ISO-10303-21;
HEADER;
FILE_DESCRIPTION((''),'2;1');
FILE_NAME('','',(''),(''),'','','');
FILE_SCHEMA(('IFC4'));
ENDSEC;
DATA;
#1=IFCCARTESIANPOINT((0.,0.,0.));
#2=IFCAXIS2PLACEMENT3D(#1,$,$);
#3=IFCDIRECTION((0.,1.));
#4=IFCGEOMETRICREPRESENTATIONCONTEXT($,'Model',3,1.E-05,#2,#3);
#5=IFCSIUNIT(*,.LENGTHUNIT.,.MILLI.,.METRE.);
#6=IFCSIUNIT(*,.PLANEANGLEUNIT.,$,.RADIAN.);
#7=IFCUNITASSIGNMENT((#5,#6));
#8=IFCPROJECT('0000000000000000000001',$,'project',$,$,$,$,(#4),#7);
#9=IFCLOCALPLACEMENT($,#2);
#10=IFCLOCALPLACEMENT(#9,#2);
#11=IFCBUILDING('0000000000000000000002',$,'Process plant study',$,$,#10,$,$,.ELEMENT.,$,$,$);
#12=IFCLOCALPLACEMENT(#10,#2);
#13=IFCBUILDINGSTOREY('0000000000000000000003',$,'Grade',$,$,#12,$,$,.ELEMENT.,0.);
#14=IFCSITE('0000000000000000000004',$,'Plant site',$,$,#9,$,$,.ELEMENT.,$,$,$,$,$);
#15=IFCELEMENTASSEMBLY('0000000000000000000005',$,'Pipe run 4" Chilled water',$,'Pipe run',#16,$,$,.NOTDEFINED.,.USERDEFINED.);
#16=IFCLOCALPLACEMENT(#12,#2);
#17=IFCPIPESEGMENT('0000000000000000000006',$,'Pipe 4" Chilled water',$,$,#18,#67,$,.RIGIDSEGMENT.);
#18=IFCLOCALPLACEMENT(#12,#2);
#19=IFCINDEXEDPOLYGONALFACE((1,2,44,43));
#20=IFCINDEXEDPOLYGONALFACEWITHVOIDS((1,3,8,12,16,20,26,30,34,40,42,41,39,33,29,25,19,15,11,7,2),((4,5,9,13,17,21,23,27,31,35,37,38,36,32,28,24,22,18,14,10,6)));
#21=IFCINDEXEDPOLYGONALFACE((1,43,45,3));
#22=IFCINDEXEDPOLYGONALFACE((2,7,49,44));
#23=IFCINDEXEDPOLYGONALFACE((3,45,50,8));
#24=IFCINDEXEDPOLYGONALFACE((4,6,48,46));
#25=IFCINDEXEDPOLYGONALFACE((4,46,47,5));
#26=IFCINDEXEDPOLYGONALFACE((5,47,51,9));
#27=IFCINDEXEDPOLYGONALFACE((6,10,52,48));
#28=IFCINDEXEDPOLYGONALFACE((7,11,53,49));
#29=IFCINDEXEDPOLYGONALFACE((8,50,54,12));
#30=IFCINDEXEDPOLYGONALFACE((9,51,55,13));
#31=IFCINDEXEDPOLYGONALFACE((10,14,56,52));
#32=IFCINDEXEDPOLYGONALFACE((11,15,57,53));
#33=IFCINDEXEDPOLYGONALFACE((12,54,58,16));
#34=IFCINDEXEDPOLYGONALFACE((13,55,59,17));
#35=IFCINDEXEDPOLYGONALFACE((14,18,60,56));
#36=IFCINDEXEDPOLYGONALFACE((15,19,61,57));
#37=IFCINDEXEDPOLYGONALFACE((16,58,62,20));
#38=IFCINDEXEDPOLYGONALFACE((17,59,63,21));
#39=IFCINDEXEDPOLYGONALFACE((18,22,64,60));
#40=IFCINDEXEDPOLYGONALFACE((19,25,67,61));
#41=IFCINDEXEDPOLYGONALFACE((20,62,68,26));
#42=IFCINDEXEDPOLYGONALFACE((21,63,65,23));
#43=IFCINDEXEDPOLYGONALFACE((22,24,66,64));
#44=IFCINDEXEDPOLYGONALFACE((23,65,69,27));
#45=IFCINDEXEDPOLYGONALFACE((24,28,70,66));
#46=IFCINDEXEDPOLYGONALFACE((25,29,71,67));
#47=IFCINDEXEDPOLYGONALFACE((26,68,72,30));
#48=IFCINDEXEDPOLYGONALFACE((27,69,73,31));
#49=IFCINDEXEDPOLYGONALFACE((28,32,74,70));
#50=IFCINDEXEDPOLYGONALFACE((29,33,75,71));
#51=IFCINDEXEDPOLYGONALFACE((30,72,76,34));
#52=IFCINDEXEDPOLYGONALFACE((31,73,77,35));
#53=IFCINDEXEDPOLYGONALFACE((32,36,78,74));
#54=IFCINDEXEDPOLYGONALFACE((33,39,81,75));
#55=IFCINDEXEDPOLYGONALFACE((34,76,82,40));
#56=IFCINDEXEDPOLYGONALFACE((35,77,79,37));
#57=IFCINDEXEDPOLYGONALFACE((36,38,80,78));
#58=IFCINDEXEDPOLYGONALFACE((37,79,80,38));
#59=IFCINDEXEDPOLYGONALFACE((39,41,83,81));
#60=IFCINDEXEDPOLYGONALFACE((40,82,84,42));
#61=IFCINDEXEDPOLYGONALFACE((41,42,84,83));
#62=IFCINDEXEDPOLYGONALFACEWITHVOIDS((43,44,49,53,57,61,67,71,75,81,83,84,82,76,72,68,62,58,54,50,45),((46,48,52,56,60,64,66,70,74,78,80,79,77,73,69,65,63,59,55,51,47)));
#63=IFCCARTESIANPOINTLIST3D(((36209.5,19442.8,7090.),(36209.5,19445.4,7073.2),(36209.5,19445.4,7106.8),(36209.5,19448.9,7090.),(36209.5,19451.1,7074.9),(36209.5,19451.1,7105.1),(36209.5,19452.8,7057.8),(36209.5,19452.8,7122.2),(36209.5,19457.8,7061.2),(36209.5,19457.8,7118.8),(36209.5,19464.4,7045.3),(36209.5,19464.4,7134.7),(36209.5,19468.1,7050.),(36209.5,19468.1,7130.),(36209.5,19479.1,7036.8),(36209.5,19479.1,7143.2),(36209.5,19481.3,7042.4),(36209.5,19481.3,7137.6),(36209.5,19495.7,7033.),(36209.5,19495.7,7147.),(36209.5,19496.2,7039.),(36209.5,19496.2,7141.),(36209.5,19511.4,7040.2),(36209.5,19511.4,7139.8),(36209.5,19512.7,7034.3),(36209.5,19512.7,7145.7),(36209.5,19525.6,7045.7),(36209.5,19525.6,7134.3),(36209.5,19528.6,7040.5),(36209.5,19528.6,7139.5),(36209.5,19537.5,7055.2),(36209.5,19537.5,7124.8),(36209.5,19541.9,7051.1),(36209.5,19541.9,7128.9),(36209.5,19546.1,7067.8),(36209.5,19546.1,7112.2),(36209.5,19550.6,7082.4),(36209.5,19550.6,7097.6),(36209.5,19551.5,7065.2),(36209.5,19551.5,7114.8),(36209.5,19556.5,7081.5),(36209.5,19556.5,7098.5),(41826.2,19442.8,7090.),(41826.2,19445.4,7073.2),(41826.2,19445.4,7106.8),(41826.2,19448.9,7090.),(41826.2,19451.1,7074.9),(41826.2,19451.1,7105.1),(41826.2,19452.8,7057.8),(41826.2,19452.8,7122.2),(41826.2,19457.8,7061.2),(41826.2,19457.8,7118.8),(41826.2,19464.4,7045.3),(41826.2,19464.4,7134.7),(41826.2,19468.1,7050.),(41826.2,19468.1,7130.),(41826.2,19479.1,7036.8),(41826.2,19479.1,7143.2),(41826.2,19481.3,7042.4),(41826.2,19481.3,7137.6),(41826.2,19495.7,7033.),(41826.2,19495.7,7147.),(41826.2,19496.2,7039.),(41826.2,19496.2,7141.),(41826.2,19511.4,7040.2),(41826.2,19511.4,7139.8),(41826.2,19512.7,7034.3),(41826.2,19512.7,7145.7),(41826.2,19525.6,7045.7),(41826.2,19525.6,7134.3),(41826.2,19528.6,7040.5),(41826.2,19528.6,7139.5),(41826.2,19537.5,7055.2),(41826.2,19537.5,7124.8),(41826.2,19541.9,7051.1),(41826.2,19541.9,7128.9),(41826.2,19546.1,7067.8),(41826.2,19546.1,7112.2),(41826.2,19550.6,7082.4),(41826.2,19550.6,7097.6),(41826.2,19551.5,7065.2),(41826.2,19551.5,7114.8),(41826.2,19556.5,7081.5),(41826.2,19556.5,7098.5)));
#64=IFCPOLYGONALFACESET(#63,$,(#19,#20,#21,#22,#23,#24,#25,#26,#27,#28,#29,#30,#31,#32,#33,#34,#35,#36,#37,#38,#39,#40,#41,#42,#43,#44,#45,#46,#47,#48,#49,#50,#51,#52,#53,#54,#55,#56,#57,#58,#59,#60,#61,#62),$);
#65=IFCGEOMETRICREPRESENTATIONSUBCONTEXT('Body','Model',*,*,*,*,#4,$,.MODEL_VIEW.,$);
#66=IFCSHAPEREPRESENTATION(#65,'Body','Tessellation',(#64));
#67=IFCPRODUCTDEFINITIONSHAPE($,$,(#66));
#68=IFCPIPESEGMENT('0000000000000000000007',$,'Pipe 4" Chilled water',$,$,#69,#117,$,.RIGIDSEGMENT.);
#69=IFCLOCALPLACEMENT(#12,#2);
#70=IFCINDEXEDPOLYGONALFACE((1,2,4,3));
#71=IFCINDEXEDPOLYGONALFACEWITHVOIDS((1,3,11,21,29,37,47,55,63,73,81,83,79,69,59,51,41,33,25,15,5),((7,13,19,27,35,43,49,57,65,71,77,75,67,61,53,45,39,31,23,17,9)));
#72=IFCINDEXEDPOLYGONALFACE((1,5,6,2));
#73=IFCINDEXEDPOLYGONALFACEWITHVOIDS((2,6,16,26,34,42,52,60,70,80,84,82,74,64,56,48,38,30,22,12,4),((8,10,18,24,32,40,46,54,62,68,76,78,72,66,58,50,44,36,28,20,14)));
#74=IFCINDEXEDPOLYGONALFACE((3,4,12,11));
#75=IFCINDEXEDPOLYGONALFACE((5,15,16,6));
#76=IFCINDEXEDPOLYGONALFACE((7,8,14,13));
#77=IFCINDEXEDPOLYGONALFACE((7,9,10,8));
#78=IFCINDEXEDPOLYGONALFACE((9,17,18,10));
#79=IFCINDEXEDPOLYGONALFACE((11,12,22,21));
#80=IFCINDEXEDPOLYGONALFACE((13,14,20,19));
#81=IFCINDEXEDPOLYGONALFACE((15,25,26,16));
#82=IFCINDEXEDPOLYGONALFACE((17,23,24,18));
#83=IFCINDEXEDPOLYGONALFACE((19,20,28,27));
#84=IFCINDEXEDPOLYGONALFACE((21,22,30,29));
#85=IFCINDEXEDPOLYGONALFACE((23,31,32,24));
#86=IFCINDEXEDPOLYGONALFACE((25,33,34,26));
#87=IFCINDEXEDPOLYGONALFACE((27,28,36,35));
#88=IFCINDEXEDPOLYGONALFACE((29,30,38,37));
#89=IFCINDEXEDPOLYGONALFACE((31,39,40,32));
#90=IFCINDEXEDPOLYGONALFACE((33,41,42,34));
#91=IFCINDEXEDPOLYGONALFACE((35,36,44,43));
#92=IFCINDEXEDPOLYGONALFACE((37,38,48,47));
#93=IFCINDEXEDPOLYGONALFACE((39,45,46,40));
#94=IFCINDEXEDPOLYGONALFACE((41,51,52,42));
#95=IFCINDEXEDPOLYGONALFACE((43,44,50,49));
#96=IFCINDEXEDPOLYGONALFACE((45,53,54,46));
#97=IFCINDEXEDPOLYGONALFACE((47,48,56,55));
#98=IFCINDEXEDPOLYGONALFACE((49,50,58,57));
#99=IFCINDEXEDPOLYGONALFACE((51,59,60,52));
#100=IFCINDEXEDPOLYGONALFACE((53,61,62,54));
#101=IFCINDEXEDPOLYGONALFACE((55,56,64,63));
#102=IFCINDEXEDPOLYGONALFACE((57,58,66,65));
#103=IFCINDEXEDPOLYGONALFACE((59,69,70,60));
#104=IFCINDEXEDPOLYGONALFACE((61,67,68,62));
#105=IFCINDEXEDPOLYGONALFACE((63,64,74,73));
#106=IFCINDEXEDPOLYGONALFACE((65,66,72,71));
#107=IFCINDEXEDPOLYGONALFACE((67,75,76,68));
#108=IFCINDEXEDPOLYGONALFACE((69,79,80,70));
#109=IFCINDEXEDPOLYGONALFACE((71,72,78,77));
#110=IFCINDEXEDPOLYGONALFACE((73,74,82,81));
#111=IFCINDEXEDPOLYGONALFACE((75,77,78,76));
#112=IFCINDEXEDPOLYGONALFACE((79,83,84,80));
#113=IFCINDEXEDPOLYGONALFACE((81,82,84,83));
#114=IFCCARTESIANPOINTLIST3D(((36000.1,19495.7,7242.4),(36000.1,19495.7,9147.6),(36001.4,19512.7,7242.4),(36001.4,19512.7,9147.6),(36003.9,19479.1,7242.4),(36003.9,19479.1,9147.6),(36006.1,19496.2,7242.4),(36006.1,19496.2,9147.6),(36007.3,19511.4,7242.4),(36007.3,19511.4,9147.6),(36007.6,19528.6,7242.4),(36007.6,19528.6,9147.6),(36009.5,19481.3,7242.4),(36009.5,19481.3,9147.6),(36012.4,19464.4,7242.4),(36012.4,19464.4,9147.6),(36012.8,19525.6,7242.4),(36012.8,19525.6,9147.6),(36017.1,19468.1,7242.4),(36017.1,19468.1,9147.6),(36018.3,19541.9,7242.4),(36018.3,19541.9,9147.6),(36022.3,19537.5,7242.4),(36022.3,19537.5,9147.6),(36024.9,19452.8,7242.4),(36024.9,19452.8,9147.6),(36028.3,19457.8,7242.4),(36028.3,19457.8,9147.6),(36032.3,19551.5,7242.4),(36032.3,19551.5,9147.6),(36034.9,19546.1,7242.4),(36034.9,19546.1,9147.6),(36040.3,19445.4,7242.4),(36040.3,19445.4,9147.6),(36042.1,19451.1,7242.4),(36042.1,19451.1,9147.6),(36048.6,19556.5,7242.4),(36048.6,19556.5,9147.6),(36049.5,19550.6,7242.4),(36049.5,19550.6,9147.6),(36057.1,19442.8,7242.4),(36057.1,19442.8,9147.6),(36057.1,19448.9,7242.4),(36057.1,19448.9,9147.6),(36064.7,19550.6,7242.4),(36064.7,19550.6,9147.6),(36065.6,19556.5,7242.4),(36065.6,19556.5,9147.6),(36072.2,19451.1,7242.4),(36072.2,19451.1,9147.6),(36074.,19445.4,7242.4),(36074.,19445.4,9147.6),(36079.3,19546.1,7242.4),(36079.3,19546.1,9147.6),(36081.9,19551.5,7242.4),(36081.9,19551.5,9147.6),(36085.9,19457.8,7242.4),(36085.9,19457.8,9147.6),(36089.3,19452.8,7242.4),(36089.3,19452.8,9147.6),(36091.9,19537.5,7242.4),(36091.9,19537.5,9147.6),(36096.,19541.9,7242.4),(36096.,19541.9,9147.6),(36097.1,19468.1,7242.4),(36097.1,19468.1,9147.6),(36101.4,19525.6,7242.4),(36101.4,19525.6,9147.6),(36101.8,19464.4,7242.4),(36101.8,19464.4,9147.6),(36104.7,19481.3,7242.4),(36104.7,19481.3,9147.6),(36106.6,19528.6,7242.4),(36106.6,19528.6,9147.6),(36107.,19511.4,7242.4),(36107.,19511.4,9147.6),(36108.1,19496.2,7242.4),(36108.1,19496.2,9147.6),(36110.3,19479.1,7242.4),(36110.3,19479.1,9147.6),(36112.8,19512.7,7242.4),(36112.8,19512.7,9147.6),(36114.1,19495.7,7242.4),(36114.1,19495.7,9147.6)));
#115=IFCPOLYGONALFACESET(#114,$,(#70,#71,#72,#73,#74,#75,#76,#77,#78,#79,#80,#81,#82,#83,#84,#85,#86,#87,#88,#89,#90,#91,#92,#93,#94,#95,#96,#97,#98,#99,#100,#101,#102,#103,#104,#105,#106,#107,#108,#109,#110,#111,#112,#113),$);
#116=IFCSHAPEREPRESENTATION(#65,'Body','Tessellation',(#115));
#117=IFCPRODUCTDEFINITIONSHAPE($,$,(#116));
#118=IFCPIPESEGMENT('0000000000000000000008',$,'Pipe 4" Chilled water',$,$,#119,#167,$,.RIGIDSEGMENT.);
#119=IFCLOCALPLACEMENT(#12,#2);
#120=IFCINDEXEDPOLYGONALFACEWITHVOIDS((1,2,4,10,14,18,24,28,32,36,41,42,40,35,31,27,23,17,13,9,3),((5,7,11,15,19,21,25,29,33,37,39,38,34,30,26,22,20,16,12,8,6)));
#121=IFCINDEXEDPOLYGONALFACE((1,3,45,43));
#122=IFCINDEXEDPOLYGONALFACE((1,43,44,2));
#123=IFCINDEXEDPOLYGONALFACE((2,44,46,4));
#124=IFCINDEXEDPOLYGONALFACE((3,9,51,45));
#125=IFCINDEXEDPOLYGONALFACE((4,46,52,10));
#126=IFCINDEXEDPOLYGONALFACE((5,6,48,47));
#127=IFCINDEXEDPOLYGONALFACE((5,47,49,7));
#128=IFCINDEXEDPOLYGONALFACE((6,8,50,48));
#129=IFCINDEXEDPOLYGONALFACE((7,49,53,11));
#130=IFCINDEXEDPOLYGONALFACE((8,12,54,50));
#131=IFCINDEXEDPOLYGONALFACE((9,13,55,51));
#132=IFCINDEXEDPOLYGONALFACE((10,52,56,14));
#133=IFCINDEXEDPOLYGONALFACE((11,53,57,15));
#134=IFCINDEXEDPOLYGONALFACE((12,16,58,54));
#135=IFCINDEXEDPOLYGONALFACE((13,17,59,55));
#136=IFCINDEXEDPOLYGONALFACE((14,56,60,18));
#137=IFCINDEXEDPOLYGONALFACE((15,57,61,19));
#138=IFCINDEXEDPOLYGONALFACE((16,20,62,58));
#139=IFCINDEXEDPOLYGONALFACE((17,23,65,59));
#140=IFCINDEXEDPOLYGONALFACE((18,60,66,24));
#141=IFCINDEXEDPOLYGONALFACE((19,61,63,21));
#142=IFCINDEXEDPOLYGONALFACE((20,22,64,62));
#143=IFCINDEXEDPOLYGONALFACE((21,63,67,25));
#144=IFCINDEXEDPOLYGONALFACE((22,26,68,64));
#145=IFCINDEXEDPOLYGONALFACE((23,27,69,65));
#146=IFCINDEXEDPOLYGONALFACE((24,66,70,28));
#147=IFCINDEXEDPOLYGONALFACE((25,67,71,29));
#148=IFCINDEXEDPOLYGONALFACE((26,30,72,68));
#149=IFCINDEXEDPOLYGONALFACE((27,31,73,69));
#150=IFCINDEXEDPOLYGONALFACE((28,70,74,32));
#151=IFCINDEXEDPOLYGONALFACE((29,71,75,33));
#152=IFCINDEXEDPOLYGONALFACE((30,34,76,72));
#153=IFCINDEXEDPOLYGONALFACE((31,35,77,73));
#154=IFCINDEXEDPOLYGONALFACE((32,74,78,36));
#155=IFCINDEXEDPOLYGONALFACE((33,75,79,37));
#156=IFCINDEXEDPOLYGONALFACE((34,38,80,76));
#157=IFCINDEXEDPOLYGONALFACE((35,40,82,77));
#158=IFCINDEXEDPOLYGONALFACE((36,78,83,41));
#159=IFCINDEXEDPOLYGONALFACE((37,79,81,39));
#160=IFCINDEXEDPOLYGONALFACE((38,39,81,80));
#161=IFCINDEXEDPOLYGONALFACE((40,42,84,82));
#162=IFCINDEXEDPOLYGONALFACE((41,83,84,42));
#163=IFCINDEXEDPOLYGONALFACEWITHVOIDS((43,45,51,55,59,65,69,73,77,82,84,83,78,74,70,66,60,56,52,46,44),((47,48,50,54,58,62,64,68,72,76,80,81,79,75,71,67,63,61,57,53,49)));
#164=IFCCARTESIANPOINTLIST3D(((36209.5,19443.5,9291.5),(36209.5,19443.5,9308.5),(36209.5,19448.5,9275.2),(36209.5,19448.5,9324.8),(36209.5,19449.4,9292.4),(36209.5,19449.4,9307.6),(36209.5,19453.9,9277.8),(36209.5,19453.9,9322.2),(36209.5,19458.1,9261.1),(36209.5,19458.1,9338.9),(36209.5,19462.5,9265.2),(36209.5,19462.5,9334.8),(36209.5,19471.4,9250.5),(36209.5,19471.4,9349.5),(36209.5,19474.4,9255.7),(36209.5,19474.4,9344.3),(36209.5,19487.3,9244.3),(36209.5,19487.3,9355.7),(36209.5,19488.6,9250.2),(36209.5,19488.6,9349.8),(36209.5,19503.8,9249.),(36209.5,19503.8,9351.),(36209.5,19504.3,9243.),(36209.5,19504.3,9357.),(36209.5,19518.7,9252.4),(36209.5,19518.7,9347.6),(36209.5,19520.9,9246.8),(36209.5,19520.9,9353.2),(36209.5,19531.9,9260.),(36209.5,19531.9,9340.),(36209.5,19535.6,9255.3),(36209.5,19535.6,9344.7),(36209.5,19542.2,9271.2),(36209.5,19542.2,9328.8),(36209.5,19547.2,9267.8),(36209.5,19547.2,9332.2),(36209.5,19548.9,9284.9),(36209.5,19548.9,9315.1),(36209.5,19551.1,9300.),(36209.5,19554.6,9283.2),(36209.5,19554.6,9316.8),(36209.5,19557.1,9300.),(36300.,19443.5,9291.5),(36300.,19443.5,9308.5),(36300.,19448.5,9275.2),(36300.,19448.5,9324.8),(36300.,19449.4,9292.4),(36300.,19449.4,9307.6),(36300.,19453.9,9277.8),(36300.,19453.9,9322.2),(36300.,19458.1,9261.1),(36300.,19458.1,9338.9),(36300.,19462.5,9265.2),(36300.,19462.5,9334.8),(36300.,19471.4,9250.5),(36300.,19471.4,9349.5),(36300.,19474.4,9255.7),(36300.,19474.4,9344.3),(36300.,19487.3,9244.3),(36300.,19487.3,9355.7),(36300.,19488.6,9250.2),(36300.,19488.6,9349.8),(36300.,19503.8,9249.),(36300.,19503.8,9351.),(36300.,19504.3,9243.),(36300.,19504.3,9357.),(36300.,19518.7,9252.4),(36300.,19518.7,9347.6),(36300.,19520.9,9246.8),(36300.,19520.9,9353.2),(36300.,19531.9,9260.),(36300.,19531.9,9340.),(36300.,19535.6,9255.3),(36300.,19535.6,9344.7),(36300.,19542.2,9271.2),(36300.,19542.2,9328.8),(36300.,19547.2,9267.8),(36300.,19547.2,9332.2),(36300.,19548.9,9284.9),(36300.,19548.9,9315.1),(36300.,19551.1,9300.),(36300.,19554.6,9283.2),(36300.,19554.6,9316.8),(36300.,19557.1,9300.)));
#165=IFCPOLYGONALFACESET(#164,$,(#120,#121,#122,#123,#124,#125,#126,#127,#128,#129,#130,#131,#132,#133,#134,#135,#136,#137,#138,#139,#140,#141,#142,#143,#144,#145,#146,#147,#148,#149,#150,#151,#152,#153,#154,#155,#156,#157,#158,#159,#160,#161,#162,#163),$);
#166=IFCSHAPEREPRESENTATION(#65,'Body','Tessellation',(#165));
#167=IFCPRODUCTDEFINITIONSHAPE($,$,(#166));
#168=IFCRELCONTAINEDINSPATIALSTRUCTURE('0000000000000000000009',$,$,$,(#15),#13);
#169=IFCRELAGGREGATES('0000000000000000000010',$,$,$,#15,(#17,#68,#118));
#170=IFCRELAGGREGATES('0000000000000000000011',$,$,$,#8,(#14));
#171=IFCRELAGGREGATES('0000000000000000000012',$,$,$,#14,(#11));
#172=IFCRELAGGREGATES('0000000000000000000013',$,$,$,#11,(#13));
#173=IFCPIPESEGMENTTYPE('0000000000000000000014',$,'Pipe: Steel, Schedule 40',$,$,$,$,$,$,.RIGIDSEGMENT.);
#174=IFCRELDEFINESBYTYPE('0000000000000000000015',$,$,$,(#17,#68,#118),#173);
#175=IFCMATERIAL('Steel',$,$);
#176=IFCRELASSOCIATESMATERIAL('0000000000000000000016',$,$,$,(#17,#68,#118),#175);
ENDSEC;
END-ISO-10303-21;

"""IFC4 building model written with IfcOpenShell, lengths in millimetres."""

from ifc_helpers import new_model, si_unit, direction, frame, origin, origin_with_axes, origin_2d, place, context, subcontext, project, spatial, hollow_circle, extrude, material, type_object, element, aggregate, save


model = new_model("IFC4")

# Units and contexts
model_context = context("Model", 3, precision=1e-05, world=origin(), true_north=direction((0.0, 1.0)))
body_context = subcontext(model_context, "Body", "Model", "MODEL_VIEW")
ifc_project = project(units=[si_unit("LENGTHUNIT", "METRE", prefix="MILLI"), si_unit("PLANEANGLEUNIT", "RADIAN")], contexts=[model_context])

# Site, building, storey
site_placement = place(None, origin())
site = spatial("IfcSite", under=ifc_project, at=site_placement, Name="Plant site", CompositionType="ELEMENT")
building_placement = place(site_placement, origin())
building = spatial("IfcBuilding", under=site, at=building_placement, Name="Process plant study", CompositionType="ELEMENT")
storey_placement = place(building_placement, origin())
storey = spatial("IfcBuildingStorey", under=building, at=storey_placement, Name="Grade", CompositionType="ELEMENT", Elevation=0.0)

# Shared definitions
ifc_material = material(Name="Steel")
pipe_segment_type = type_object("IfcPipeSegmentType", Name="Pipe: Steel, Schedule 40", PredefinedType="RIGIDSEGMENT")

# Element assembly, pipe segments
assembly_1_placement = place(storey_placement, origin_with_axes())
assembly_1 = element("IfcElementAssembly", 1, at=assembly_1_placement, inside=storey, Name="Pipe run 4\" Chilled water", ObjectType="Pipe run", AssemblyPlace="NOTDEFINED", PredefinedType="USERDEFINED")
pipe_segment_1_placement = place(storey_placement, origin_with_axes())
pipe_segment_1 = element("IfcPipeSegment", 2, at=pipe_segment_1_placement, type_object=pipe_segment_type, material=ifc_material, Name="Pipe 4\" Chilled water", PredefinedType="RIGIDSEGMENT", context=body_context, shape_type="SweptSolid", body=[
    extrude(hollow_circle(Radius=57.1, WallThickness=6.0, at=origin_2d()), frame((41826.2, 19500.0, 7090.0), z_axis=(-1.0, 0.0, 0.0), x_axis=(0.0, -1.0, 0.0)), (0.0, 0.0, 1.0), 5616.7),
])
pipe_segment_2_placement = place(storey_placement, origin_with_axes())
pipe_segment_2 = element("IfcPipeSegment", 3, at=pipe_segment_2_placement, type_object=pipe_segment_type, material=ifc_material, Name="Pipe 4\" Chilled water", PredefinedType="RIGIDSEGMENT", context=body_context, shape_type="SweptSolid", body=[
    extrude(hollow_circle(Radius=57.1, WallThickness=6.0, at=origin_2d()), frame((36057.1, 19500.0, 7242.4), z_axis=(0.0, 0.0, 1.0), x_axis=(0.0, -1.0, 0.0)), (0.0, 0.0, 1.0), 1905.2),
])
pipe_segment_3_placement = place(storey_placement, origin_with_axes())
pipe_segment_3 = element("IfcPipeSegment", 4, at=pipe_segment_3_placement, type_object=pipe_segment_type, material=ifc_material, Name="Pipe 4\" Chilled water", PredefinedType="RIGIDSEGMENT", context=body_context, shape_type="SweptSolid", body=[
    extrude(hollow_circle(Radius=57.1, WallThickness=6.0, at=origin_2d()), frame((36209.5, 19500.0, 9300.0), z_axis=(1.0, 0.0, 0.0), x_axis=(0.0, 1.0, 0.0)), (0.0, 0.0, 1.0), 90.5),
])

aggregate(assembly_1, [pipe_segment_1, pipe_segment_2, pipe_segment_3])

save(model, "model.ifc")
